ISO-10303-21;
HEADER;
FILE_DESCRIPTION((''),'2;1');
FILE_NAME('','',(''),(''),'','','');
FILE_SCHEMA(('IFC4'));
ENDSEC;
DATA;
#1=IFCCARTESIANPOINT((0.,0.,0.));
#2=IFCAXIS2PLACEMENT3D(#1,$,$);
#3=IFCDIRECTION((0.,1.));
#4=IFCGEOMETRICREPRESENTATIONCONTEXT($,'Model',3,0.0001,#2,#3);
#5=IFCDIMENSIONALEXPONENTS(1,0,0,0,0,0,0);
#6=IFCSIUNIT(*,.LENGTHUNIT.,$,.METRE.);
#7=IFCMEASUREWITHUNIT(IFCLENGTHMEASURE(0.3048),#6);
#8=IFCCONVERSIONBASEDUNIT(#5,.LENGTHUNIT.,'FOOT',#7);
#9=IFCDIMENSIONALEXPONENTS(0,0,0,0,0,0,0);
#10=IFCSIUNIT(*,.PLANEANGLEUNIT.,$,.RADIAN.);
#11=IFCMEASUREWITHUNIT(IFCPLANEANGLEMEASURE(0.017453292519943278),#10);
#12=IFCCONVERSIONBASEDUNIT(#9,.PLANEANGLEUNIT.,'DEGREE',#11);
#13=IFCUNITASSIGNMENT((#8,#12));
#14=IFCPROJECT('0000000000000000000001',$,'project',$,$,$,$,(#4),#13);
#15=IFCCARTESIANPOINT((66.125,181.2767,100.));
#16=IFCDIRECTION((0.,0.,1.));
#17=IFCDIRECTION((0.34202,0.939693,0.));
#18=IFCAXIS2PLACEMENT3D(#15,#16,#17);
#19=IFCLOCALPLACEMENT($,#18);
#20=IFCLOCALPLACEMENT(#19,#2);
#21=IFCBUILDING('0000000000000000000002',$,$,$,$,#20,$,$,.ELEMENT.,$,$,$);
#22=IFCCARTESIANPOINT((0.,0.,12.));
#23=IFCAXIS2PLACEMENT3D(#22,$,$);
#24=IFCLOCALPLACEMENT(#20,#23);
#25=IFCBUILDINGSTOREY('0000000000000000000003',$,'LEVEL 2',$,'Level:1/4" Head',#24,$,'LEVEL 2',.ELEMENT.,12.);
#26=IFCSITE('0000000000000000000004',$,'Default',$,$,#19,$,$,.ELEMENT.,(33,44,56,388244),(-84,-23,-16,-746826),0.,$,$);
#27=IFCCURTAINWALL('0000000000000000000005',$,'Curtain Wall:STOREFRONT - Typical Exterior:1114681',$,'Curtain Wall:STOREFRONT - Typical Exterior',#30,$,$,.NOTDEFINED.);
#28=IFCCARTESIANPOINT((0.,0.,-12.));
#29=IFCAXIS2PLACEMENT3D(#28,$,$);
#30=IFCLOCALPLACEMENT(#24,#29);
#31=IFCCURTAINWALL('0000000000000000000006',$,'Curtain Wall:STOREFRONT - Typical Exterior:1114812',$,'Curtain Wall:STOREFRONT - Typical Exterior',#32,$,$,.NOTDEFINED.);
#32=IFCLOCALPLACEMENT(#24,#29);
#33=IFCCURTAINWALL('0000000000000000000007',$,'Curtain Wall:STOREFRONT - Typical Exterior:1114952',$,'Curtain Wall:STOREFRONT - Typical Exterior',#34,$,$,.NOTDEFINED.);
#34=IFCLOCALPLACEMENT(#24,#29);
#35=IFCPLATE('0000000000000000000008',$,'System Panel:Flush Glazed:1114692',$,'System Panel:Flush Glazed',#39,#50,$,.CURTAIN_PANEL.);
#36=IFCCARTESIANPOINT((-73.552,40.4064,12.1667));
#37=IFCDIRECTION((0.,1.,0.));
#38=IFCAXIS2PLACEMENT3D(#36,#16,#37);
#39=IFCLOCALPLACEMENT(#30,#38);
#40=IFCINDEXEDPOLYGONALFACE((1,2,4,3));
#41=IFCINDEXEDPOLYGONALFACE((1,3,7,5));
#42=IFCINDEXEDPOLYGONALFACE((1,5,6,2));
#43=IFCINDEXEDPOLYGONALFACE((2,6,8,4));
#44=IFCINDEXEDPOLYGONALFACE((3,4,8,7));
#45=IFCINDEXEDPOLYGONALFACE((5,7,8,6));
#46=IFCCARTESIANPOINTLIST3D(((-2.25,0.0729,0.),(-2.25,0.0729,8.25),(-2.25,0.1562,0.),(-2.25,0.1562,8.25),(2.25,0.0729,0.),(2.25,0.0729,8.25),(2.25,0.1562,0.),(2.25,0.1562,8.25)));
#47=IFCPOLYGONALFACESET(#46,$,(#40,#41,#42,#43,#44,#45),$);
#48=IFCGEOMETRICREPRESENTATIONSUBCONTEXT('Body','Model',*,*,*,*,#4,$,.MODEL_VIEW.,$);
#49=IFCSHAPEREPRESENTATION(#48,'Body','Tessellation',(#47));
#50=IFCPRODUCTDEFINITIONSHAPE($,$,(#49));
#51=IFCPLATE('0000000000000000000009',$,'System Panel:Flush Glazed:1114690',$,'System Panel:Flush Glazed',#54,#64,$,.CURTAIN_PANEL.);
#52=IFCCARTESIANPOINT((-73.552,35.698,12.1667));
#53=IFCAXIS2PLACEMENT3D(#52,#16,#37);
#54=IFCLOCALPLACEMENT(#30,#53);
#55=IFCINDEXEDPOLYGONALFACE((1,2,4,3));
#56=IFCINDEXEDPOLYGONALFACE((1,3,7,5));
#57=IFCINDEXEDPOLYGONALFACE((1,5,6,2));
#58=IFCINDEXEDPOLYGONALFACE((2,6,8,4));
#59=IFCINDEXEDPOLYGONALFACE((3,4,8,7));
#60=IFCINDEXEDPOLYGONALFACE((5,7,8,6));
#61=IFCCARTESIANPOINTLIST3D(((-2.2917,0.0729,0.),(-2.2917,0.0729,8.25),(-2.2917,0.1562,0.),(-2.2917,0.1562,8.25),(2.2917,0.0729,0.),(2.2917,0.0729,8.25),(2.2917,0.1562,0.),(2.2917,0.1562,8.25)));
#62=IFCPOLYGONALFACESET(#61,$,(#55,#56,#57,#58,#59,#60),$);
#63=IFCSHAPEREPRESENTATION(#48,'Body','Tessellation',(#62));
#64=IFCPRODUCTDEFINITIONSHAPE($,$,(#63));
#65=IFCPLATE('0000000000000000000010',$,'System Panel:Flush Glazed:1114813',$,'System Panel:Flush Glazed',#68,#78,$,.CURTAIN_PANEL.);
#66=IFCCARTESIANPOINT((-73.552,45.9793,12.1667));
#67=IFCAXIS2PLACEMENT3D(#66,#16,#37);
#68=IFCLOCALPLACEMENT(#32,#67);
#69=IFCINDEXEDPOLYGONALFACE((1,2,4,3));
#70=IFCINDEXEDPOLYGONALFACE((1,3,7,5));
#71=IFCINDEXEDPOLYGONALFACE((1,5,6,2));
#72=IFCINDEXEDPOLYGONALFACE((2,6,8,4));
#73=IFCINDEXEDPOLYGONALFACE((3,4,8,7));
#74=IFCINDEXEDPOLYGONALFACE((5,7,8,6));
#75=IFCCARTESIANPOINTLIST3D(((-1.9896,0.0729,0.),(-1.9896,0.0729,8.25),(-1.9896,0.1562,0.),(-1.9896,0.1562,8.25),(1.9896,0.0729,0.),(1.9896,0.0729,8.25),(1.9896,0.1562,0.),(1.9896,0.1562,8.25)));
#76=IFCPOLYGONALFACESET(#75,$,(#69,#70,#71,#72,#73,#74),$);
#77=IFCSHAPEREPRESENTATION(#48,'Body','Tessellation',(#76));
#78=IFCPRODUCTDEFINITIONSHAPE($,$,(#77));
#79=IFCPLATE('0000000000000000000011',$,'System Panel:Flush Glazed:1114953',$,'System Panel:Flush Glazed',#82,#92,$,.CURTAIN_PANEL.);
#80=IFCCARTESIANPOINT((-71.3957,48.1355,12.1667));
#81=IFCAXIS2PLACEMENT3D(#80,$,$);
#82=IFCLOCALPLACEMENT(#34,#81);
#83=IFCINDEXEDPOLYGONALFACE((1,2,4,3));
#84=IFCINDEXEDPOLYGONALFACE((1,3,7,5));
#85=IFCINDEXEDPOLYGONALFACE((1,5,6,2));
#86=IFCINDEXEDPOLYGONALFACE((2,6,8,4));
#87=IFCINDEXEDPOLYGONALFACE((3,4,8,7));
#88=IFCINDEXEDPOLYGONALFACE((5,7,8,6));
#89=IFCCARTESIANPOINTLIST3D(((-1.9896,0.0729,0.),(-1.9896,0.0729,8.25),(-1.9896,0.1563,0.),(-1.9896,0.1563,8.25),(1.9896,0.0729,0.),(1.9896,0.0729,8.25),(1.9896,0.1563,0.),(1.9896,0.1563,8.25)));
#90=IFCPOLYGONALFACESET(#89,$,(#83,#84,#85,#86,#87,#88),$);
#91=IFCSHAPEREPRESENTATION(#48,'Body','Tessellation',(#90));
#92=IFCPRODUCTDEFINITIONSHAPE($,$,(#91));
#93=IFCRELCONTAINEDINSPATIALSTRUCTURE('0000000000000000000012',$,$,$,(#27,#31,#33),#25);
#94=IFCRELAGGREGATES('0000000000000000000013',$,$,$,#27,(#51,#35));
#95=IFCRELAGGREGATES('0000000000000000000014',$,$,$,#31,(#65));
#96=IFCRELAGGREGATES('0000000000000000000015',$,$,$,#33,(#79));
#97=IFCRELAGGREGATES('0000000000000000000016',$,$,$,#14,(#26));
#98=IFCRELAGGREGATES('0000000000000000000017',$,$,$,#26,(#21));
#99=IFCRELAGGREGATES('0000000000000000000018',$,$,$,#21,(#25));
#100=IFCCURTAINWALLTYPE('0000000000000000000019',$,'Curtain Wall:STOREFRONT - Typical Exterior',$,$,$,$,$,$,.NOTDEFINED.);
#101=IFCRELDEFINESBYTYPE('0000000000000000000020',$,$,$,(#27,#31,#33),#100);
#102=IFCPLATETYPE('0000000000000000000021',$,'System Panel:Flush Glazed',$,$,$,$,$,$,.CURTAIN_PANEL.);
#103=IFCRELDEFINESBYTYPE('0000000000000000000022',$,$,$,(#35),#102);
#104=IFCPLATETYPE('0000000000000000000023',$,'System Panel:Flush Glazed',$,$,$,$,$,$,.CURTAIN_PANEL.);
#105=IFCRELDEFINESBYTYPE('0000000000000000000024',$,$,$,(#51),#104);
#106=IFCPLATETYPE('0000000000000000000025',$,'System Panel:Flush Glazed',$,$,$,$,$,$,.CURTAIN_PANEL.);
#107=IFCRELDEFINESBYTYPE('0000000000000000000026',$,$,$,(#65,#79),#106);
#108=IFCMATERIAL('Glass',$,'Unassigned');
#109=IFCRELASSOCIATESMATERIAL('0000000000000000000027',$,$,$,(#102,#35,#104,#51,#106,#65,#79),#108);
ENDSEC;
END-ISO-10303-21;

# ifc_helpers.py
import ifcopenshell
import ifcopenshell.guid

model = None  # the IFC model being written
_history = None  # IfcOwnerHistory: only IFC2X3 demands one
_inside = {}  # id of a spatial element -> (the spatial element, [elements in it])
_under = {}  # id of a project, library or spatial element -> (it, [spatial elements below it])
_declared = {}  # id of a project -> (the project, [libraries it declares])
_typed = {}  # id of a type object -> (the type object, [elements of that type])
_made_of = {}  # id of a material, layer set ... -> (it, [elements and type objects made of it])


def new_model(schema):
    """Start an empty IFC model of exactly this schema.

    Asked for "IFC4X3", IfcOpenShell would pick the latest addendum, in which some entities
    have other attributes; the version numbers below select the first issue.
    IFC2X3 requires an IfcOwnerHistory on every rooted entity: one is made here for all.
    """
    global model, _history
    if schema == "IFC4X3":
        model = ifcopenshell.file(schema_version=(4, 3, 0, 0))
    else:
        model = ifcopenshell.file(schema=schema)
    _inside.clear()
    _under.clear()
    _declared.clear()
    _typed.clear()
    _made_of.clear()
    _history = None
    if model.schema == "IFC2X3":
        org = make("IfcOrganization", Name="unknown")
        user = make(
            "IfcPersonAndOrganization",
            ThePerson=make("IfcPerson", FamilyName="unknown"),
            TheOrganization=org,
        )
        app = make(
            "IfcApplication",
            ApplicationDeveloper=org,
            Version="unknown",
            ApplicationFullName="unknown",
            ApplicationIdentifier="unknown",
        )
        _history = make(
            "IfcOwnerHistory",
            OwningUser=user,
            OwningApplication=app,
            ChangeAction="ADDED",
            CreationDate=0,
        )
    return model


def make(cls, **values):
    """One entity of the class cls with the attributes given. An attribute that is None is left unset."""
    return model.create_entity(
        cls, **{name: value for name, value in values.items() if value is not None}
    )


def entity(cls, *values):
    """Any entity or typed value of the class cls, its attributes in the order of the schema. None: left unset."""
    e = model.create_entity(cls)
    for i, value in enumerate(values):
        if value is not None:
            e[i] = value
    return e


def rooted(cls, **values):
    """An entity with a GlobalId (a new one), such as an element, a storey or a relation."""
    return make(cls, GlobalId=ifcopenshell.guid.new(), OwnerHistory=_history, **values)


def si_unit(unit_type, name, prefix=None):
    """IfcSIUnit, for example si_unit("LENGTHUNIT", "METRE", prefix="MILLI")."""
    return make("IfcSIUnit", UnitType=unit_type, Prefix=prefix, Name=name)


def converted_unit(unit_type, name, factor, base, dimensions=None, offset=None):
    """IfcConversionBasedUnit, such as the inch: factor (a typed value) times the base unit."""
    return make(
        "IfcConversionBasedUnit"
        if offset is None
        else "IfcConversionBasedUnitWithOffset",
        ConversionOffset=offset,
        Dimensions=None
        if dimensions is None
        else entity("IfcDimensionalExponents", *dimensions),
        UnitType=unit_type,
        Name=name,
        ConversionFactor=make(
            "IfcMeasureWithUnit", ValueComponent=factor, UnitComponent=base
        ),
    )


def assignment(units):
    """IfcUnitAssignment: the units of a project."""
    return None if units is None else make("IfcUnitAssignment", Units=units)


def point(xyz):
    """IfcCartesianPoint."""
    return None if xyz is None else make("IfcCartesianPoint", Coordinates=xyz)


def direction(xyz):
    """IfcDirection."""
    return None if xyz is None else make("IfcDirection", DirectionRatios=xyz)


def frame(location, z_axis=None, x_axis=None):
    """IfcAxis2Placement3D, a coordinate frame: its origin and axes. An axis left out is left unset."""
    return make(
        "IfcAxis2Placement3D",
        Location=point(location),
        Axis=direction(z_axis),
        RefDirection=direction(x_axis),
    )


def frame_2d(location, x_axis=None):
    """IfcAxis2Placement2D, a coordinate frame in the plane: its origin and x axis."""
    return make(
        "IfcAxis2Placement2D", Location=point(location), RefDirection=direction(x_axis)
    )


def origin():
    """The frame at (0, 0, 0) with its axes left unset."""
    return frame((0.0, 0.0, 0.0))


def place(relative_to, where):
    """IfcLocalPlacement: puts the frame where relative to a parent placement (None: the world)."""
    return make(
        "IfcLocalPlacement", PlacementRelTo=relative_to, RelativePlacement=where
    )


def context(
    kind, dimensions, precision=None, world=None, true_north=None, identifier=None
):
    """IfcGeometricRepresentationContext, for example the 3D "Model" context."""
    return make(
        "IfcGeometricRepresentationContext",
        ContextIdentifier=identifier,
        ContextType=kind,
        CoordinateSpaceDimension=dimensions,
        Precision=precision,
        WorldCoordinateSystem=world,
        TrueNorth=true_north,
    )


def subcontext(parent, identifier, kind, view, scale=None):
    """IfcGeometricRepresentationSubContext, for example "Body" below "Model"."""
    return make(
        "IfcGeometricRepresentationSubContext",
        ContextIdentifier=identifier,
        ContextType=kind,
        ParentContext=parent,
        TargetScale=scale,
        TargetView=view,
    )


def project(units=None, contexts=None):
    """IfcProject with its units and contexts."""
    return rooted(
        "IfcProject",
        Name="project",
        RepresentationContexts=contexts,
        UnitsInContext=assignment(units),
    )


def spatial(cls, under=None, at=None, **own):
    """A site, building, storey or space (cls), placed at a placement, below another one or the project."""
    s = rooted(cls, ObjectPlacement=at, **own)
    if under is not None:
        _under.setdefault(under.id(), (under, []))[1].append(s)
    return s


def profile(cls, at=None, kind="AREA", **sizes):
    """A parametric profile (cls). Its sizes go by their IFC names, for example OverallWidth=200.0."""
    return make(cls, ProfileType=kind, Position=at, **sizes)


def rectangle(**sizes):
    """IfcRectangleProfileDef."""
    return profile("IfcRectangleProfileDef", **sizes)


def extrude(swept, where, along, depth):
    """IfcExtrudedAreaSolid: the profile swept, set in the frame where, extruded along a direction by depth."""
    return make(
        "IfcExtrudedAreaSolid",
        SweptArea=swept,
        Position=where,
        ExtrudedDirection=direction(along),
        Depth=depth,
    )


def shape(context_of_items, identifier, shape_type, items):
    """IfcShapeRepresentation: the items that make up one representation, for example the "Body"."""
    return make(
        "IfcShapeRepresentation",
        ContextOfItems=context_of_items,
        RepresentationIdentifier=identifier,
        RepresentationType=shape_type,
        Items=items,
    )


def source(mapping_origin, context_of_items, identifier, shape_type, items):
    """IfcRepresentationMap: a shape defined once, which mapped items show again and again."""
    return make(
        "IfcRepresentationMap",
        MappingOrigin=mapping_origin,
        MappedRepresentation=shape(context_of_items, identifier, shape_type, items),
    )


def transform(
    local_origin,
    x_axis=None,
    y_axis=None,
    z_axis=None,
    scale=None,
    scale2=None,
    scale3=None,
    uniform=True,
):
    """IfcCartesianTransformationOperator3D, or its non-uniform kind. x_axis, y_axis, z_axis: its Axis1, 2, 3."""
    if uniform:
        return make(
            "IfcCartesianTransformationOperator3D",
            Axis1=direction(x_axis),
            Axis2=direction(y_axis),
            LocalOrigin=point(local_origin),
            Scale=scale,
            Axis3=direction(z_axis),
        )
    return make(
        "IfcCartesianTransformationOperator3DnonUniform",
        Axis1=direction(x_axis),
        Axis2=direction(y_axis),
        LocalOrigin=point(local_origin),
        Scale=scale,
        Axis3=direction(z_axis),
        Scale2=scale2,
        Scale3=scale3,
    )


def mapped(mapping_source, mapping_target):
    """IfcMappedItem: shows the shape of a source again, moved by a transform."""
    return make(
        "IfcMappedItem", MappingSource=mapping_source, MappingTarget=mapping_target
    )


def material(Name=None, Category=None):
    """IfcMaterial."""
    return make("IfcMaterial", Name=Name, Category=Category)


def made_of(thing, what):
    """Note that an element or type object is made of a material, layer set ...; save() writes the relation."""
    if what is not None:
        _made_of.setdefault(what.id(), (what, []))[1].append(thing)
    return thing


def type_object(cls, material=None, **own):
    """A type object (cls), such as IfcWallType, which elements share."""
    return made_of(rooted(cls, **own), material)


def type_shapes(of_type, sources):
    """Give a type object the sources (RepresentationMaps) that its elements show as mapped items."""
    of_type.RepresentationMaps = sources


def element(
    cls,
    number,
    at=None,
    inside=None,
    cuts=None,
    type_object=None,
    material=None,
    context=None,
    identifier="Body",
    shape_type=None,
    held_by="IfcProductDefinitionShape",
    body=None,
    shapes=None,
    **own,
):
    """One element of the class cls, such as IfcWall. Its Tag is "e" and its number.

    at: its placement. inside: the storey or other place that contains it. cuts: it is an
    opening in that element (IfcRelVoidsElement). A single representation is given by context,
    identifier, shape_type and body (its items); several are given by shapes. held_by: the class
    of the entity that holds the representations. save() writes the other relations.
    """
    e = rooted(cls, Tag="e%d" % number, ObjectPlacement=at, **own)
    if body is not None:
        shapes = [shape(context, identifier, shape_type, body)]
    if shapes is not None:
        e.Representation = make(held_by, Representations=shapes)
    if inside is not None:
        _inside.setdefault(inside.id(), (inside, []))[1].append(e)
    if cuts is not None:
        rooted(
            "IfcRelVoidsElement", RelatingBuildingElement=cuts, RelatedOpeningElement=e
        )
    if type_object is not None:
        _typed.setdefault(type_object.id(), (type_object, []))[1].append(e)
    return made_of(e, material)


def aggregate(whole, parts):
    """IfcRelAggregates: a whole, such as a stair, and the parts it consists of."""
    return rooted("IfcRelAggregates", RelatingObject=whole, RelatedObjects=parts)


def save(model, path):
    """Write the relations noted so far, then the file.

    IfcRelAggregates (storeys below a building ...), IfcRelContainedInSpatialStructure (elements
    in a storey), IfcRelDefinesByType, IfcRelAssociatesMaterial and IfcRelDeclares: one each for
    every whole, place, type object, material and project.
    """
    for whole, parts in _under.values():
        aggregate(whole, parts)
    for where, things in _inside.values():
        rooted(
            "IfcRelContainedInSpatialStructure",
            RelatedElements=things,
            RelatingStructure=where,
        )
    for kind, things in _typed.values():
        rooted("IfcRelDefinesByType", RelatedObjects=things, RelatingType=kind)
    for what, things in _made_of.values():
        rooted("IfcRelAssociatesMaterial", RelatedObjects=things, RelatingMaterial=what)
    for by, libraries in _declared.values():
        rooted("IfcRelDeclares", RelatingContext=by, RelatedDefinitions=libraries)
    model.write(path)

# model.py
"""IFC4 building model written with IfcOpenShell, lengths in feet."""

from ifc_helpers import new_model, entity, si_unit, converted_unit, direction, frame, frame_2d, origin, place, context, subcontext, project, spatial, rectangle, extrude, source, transform, mapped, material, type_object, type_shapes, element, aggregate, save


model = new_model("IFC4")

# Units and contexts
model_context = context("Model", 3, precision=0.0001, world=origin(), true_north=direction((0.0, 1.0)))
body_context = subcontext(model_context, "Body", "Model", "MODEL_VIEW")
ifc_project = project(units=[converted_unit("LENGTHUNIT", "FOOT", entity("IfcLengthMeasure", 0.3048), si_unit("LENGTHUNIT", "METRE"), dimensions=[1, 0, 0, 0, 0, 0, 0]), converted_unit("PLANEANGLEUNIT", "DEGREE", entity("IfcPlaneAngleMeasure", 0.017453292519943278), si_unit("PLANEANGLEUNIT", "RADIAN"), dimensions=[0, 0, 0, 0, 0, 0, 0])], contexts=[model_context])

# Site, building, storey
site_placement = place(None, frame((66.125, 181.2767, 100.0), z_axis=(0.0, 0.0, 1.0), x_axis=(0.34202, 0.939693, 0.0)))
site = spatial("IfcSite", under=ifc_project, at=site_placement, Name="Default", CompositionType="ELEMENT", RefLatitude=(33, 44, 56, 388244), RefLongitude=(-84, -23, -16, -746826), RefElevation=0.0)
building_placement = place(site_placement, origin())
building = spatial("IfcBuilding", under=site, at=building_placement, CompositionType="ELEMENT")
storey_placement = place(building_placement, frame((0.0, 0.0, 12.0)))
storey = spatial("IfcBuildingStorey", under=building, at=storey_placement, Name="LEVEL 2", ObjectType="Level:1/4\" Head", LongName="LEVEL 2", CompositionType="ELEMENT", Elevation=12.0)

# Curtain wall
curtain_wall_type = type_object("IfcCurtainWallType", Name="Curtain Wall:STOREFRONT - Typical Exterior", PredefinedType="NOTDEFINED")
curtain_wall_1_placement = place(storey_placement, frame((0.0, 0.0, -12.0)))
curtain_wall_1 = element("IfcCurtainWall", 1, at=curtain_wall_1_placement, inside=storey, type_object=curtain_wall_type, Name="Curtain Wall:STOREFRONT - Typical Exterior:1114681", ObjectType="Curtain Wall:STOREFRONT - Typical Exterior", PredefinedType="NOTDEFINED")

# Curtain walls
curtain_wall_2_placement = place(storey_placement, frame((0.0, 0.0, -12.0)))
curtain_wall_2 = element("IfcCurtainWall", 2, at=curtain_wall_2_placement, inside=storey, type_object=curtain_wall_type, Name="Curtain Wall:STOREFRONT - Typical Exterior:1114812", ObjectType="Curtain Wall:STOREFRONT - Typical Exterior", PredefinedType="NOTDEFINED")
curtain_wall_3_placement = place(storey_placement, frame((0.0, 0.0, -12.0)))
curtain_wall_3 = element("IfcCurtainWall", 3, at=curtain_wall_3_placement, inside=storey, type_object=curtain_wall_type, Name="Curtain Wall:STOREFRONT - Typical Exterior:1114952", ObjectType="Curtain Wall:STOREFRONT - Typical Exterior", PredefinedType="NOTDEFINED")

# Plates
ifc_material_1 = material(Name="Glass", Category="Unassigned")
plate_type_1 = type_object("IfcPlateType", Name="System Panel:Flush Glazed", PredefinedType="CURTAIN_PANEL", material=ifc_material_1)
shared_shape_1 = source(origin(), body_context, "Body", "SweptSolid", [
    extrude(rectangle(XDim=0.0833, YDim=4.5, at=frame_2d((0.0, 0.0), x_axis=(1.0, 0.0))), frame((0.0, 0.1146, 0.0), z_axis=(0.0, 0.0, 1.0), x_axis=(0.0, 1.0, 0.0)), (0.0, 0.0, 1.0), 8.25),
])
type_shapes(plate_type_1, [shared_shape_1])
plate_1_placement = place(curtain_wall_1_placement, frame((-73.552, 40.4064, 12.1667), z_axis=(0.0, 0.0, 1.0), x_axis=(0.0, 1.0, 0.0)))
plate_1 = element("IfcPlate", 4, at=plate_1_placement, type_object=plate_type_1, material=ifc_material_1, Name="System Panel:Flush Glazed:1114692", ObjectType="System Panel:Flush Glazed", PredefinedType="CURTAIN_PANEL", context=body_context, shape_type="MappedRepresentation", body=[
    mapped(shared_shape_1, transform((0.0, 0.0, 0.0), scale=1.0)),
])
plate_type_2 = type_object("IfcPlateType", Name="System Panel:Flush Glazed", PredefinedType="CURTAIN_PANEL", material=ifc_material_1)
shared_shape_2 = source(origin(), body_context, "Body", "SweptSolid", [
    extrude(rectangle(XDim=0.0833, YDim=4.5833, at=frame_2d((0.0, 0.0), x_axis=(1.0, 0.0))), frame((0.0, 0.1146, 0.0), z_axis=(0.0, 0.0, 1.0), x_axis=(0.0, 1.0, 0.0)), (0.0, 0.0, 1.0), 8.25),
])
type_shapes(plate_type_2, [shared_shape_2])
plate_2_placement = place(curtain_wall_1_placement, frame((-73.552, 35.698, 12.1667), z_axis=(0.0, 0.0, 1.0), x_axis=(0.0, 1.0, 0.0)))
plate_2 = element("IfcPlate", 5, at=plate_2_placement, type_object=plate_type_2, material=ifc_material_1, Name="System Panel:Flush Glazed:1114690", ObjectType="System Panel:Flush Glazed", PredefinedType="CURTAIN_PANEL", context=body_context, shape_type="MappedRepresentation", body=[
    mapped(shared_shape_2, transform((0.0, 0.0, 0.0), scale=1.0)),
])
aggregate(curtain_wall_1, [plate_2, plate_1])
plate_type_3 = type_object("IfcPlateType", Name="System Panel:Flush Glazed", PredefinedType="CURTAIN_PANEL", material=ifc_material_1)
shared_shape_3 = source(origin(), body_context, "Body", "SweptSolid", [
    extrude(rectangle(XDim=0.0833, YDim=3.9792, at=frame_2d((0.0, 0.0), x_axis=(1.0, 0.0))), frame((0.0, 0.1146, 0.0), z_axis=(0.0, 0.0, 1.0), x_axis=(0.0, 1.0, 0.0)), (0.0, 0.0, 1.0), 8.25),
])
type_shapes(plate_type_3, [shared_shape_3])
plate_3_placement = place(curtain_wall_2_placement, frame((-73.552, 45.9793, 12.1667), z_axis=(0.0, 0.0, 1.0), x_axis=(0.0, 1.0, 0.0)))
plate_3 = element("IfcPlate", 6, at=plate_3_placement, type_object=plate_type_3, material=ifc_material_1, Name="System Panel:Flush Glazed:1114813", ObjectType="System Panel:Flush Glazed", PredefinedType="CURTAIN_PANEL", context=body_context, shape_type="MappedRepresentation", body=[
    mapped(shared_shape_3, transform((0.0, 0.0, 0.0), scale=1.0)),
])
aggregate(curtain_wall_2, [plate_3])
plate_4_placement = place(curtain_wall_3_placement, frame((-71.3957, 48.1355, 12.1667)))
plate_4 = element("IfcPlate", 7, at=plate_4_placement, type_object=plate_type_3, material=ifc_material_1, Name="System Panel:Flush Glazed:1114953", ObjectType="System Panel:Flush Glazed", PredefinedType="CURTAIN_PANEL", context=body_context, shape_type="MappedRepresentation", body=[
    mapped(shared_shape_3, transform((0.0, 0.0, 0.0), scale=1.0)),
])
aggregate(curtain_wall_3, [plate_4])

save(model, "model.ifc")
